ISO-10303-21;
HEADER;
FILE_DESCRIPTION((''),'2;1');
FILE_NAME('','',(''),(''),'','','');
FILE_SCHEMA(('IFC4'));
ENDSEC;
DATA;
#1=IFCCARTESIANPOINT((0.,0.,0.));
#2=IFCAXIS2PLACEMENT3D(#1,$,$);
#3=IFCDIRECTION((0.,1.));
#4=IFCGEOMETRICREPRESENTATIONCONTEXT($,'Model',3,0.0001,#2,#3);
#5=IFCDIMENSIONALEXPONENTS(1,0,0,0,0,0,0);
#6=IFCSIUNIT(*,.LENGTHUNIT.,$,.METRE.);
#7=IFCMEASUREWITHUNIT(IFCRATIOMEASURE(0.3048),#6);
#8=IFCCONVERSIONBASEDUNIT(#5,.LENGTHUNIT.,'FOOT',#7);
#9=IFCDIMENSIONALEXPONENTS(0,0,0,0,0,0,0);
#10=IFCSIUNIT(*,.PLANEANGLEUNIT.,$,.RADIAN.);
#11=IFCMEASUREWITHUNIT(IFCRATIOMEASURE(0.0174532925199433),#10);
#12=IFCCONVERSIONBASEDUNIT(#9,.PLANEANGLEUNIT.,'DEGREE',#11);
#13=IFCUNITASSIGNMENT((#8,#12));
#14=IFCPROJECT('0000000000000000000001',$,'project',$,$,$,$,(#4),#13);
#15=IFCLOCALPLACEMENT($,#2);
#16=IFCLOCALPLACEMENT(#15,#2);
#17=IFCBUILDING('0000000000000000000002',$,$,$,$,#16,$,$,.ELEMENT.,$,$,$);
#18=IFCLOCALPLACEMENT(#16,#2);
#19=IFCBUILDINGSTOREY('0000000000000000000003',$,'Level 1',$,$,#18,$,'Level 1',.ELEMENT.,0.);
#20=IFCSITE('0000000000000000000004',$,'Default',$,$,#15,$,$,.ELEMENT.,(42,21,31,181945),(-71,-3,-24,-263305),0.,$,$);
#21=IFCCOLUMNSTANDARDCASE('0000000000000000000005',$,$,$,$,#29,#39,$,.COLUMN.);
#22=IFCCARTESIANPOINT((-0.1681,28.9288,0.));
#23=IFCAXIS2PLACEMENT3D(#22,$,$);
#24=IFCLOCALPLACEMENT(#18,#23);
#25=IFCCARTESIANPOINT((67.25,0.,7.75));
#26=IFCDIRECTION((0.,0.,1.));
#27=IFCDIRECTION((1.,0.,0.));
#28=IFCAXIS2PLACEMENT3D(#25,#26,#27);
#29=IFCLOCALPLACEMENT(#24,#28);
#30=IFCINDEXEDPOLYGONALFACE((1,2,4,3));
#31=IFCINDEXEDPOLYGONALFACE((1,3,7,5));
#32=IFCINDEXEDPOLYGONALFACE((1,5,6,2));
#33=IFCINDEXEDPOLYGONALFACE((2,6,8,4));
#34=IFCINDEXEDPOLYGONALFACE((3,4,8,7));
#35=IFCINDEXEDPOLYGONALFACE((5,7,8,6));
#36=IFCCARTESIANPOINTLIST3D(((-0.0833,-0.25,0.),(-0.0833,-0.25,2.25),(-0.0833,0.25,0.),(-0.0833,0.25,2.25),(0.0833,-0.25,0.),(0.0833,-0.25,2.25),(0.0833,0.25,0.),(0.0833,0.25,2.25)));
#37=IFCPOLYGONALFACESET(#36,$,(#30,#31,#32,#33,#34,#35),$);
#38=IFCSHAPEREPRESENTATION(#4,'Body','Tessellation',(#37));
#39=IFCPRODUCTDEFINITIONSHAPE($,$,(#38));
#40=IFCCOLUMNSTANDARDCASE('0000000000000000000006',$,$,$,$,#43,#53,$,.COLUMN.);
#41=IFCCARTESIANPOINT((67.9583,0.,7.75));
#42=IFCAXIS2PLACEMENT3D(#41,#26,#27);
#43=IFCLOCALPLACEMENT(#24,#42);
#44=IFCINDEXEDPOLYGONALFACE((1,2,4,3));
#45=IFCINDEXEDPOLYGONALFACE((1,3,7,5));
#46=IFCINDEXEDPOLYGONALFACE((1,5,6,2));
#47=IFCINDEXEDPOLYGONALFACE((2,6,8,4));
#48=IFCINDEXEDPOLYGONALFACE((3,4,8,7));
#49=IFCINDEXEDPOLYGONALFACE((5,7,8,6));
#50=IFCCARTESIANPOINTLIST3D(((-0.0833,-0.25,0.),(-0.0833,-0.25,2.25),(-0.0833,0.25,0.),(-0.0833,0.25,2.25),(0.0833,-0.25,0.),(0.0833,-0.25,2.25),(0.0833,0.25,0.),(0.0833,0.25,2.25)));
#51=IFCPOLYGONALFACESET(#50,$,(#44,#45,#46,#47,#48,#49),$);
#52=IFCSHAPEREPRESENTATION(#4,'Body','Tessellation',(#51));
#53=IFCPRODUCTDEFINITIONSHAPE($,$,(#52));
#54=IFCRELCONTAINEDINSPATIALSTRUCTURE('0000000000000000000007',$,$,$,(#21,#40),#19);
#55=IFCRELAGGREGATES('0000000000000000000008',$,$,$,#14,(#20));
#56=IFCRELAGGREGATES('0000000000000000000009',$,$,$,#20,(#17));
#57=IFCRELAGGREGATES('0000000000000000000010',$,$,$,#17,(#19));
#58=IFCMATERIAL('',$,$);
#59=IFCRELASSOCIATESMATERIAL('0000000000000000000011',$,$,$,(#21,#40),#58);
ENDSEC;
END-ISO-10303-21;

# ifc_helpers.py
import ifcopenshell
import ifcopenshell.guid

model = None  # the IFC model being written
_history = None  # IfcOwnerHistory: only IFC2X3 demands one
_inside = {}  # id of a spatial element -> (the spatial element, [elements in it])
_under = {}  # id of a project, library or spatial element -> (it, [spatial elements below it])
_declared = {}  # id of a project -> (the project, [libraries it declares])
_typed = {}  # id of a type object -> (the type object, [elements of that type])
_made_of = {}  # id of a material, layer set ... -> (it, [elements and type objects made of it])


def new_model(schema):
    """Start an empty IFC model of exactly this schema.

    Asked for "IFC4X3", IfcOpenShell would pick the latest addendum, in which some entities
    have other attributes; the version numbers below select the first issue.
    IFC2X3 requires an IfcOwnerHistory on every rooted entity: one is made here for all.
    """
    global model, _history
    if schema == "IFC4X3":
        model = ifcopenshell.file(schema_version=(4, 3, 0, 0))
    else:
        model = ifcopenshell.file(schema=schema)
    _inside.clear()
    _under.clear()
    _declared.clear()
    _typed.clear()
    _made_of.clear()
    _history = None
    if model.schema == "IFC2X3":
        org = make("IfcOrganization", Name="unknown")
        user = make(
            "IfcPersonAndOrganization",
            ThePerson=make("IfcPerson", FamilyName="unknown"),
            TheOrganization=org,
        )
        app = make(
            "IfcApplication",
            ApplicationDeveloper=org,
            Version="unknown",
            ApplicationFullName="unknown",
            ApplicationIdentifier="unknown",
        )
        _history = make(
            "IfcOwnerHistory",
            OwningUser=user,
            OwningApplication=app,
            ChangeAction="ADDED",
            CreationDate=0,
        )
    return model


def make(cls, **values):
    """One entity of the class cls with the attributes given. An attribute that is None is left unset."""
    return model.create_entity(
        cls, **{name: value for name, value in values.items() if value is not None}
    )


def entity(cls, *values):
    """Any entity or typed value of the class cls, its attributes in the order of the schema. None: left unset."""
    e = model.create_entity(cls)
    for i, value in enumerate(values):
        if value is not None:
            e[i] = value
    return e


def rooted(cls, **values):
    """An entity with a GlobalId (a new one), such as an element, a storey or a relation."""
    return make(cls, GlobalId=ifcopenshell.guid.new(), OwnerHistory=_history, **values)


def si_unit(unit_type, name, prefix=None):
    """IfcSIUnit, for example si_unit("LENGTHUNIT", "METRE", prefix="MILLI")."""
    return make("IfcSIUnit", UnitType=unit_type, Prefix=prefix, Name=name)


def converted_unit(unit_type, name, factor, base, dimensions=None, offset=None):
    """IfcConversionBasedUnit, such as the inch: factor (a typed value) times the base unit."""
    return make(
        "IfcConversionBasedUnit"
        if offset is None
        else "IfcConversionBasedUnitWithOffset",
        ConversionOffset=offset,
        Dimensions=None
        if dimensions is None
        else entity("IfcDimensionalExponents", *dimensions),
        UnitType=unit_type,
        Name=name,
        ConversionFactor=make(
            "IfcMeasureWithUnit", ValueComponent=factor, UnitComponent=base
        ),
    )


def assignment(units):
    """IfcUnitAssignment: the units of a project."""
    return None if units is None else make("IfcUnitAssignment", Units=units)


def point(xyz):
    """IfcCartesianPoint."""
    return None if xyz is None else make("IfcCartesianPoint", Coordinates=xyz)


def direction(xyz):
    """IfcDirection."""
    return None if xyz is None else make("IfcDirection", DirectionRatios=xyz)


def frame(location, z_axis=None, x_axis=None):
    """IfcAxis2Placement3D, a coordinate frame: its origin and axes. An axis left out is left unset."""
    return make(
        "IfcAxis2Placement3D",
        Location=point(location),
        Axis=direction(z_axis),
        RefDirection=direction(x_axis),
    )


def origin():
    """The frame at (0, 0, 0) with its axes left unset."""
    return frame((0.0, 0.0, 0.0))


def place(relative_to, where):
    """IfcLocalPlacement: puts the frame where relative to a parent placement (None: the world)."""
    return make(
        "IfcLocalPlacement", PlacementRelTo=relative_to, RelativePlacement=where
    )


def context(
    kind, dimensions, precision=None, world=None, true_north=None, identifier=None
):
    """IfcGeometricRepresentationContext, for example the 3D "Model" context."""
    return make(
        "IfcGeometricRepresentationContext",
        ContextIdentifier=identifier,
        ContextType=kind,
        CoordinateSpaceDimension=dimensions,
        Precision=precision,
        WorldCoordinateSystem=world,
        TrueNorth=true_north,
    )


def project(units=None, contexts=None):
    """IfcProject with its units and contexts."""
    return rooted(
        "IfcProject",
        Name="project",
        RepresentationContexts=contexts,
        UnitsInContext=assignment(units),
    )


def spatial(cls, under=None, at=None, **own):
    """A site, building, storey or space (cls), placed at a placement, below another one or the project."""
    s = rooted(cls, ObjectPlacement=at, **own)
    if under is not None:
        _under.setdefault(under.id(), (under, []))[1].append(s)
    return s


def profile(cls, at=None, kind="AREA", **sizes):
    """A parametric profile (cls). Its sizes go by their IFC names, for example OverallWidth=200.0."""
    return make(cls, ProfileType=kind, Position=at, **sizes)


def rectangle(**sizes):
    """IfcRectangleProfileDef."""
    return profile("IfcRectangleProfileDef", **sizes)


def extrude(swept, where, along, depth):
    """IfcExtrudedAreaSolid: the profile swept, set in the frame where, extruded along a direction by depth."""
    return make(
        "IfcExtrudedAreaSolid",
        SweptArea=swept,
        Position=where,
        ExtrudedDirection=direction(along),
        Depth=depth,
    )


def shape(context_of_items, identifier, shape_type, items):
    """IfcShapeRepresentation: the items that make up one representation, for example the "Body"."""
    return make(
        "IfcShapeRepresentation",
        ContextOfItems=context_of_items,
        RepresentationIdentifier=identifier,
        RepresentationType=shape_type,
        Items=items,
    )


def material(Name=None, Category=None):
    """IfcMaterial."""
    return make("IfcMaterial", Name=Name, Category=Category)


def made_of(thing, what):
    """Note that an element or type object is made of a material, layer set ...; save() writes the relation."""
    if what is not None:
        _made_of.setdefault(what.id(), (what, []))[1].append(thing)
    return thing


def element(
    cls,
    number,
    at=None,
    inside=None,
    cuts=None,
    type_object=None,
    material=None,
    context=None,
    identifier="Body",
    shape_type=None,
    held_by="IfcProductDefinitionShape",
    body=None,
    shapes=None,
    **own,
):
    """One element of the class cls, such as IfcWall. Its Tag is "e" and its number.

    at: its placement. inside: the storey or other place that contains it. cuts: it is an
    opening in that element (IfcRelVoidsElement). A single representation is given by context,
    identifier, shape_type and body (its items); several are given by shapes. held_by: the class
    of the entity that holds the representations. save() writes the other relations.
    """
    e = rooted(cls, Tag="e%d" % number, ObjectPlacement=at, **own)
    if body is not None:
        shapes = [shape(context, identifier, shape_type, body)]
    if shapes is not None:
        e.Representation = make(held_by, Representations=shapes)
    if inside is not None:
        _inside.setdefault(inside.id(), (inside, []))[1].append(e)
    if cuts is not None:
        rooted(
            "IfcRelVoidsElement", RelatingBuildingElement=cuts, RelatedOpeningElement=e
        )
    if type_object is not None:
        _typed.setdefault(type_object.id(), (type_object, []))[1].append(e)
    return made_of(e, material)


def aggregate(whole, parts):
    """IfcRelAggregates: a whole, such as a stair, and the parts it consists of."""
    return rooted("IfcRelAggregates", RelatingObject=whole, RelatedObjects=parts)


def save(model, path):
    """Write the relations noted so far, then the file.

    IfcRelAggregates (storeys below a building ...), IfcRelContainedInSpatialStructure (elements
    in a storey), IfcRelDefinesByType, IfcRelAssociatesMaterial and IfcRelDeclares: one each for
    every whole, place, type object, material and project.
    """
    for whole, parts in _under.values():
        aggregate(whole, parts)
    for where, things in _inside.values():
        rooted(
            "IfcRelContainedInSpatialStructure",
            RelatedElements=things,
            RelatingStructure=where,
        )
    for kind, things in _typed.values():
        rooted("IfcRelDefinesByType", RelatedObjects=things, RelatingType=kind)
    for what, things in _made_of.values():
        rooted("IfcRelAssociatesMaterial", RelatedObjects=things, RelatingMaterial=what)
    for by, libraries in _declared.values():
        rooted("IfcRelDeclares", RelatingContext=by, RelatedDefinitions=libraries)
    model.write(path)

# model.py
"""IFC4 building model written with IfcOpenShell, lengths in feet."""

from ifc_helpers import new_model, entity, si_unit, converted_unit, direction, frame, origin, place, context, project, spatial, rectangle, extrude, material, element, save


model = new_model("IFC4")

# Units and contexts
model_context = context("Model", 3, precision=0.0001, world=origin(), true_north=direction((0.0, 1.0)))
ifc_project = project(units=[converted_unit("LENGTHUNIT", "FOOT", entity("IfcRatioMeasure", 0.3048), si_unit("LENGTHUNIT", "METRE"), dimensions=[1, 0, 0, 0, 0, 0, 0]), converted_unit("PLANEANGLEUNIT", "DEGREE", entity("IfcRatioMeasure", 0.0174532925199433), si_unit("PLANEANGLEUNIT", "RADIAN"), dimensions=[0, 0, 0, 0, 0, 0, 0])], contexts=[model_context])

# Site, building, storey
site_placement = place(None, origin())
site = spatial("IfcSite", under=ifc_project, at=site_placement, Name="Default", CompositionType="ELEMENT", RefLatitude=(42, 21, 31, 181945), RefLongitude=(-71, -3, -24, -263305), RefElevation=0.0)
building_placement = place(site_placement, origin())
building = spatial("IfcBuilding", under=site, at=building_placement, CompositionType="ELEMENT")
storey_placement = place(building_placement, origin())
storey = spatial("IfcBuildingStorey", under=building, at=storey_placement, Name="Level 1", LongName="Level 1", CompositionType="ELEMENT", Elevation=0.0)

# Columns
placement = place(storey_placement, frame((-0.1681, 28.9288, 0.0)))
ifc_material_1 = material(Name="")
for number, where, z_axis, x_axis in (
    (1, (67.25, 0.0, 7.75), (0.0, 0.0, 1.0), (1.0, 0.0, 0.0)),
    (2, (67.9583, 0.0, 7.75), (0.0, 0.0, 1.0), (1.0, 0.0, 0.0)),
):
    element("IfcColumnStandardCase", number, at=place(placement, frame(where, z_axis=z_axis, x_axis=x_axis)), inside=storey, material=ifc_material_1, PredefinedType="COLUMN", context=model_context, shape_type="SweptSolid", body=[
        extrude(rectangle(XDim=0.1667, YDim=0.5), origin(), (0.0, 0.0, 1.0), 2.25),
    ])

save(model, "model.ifc")
